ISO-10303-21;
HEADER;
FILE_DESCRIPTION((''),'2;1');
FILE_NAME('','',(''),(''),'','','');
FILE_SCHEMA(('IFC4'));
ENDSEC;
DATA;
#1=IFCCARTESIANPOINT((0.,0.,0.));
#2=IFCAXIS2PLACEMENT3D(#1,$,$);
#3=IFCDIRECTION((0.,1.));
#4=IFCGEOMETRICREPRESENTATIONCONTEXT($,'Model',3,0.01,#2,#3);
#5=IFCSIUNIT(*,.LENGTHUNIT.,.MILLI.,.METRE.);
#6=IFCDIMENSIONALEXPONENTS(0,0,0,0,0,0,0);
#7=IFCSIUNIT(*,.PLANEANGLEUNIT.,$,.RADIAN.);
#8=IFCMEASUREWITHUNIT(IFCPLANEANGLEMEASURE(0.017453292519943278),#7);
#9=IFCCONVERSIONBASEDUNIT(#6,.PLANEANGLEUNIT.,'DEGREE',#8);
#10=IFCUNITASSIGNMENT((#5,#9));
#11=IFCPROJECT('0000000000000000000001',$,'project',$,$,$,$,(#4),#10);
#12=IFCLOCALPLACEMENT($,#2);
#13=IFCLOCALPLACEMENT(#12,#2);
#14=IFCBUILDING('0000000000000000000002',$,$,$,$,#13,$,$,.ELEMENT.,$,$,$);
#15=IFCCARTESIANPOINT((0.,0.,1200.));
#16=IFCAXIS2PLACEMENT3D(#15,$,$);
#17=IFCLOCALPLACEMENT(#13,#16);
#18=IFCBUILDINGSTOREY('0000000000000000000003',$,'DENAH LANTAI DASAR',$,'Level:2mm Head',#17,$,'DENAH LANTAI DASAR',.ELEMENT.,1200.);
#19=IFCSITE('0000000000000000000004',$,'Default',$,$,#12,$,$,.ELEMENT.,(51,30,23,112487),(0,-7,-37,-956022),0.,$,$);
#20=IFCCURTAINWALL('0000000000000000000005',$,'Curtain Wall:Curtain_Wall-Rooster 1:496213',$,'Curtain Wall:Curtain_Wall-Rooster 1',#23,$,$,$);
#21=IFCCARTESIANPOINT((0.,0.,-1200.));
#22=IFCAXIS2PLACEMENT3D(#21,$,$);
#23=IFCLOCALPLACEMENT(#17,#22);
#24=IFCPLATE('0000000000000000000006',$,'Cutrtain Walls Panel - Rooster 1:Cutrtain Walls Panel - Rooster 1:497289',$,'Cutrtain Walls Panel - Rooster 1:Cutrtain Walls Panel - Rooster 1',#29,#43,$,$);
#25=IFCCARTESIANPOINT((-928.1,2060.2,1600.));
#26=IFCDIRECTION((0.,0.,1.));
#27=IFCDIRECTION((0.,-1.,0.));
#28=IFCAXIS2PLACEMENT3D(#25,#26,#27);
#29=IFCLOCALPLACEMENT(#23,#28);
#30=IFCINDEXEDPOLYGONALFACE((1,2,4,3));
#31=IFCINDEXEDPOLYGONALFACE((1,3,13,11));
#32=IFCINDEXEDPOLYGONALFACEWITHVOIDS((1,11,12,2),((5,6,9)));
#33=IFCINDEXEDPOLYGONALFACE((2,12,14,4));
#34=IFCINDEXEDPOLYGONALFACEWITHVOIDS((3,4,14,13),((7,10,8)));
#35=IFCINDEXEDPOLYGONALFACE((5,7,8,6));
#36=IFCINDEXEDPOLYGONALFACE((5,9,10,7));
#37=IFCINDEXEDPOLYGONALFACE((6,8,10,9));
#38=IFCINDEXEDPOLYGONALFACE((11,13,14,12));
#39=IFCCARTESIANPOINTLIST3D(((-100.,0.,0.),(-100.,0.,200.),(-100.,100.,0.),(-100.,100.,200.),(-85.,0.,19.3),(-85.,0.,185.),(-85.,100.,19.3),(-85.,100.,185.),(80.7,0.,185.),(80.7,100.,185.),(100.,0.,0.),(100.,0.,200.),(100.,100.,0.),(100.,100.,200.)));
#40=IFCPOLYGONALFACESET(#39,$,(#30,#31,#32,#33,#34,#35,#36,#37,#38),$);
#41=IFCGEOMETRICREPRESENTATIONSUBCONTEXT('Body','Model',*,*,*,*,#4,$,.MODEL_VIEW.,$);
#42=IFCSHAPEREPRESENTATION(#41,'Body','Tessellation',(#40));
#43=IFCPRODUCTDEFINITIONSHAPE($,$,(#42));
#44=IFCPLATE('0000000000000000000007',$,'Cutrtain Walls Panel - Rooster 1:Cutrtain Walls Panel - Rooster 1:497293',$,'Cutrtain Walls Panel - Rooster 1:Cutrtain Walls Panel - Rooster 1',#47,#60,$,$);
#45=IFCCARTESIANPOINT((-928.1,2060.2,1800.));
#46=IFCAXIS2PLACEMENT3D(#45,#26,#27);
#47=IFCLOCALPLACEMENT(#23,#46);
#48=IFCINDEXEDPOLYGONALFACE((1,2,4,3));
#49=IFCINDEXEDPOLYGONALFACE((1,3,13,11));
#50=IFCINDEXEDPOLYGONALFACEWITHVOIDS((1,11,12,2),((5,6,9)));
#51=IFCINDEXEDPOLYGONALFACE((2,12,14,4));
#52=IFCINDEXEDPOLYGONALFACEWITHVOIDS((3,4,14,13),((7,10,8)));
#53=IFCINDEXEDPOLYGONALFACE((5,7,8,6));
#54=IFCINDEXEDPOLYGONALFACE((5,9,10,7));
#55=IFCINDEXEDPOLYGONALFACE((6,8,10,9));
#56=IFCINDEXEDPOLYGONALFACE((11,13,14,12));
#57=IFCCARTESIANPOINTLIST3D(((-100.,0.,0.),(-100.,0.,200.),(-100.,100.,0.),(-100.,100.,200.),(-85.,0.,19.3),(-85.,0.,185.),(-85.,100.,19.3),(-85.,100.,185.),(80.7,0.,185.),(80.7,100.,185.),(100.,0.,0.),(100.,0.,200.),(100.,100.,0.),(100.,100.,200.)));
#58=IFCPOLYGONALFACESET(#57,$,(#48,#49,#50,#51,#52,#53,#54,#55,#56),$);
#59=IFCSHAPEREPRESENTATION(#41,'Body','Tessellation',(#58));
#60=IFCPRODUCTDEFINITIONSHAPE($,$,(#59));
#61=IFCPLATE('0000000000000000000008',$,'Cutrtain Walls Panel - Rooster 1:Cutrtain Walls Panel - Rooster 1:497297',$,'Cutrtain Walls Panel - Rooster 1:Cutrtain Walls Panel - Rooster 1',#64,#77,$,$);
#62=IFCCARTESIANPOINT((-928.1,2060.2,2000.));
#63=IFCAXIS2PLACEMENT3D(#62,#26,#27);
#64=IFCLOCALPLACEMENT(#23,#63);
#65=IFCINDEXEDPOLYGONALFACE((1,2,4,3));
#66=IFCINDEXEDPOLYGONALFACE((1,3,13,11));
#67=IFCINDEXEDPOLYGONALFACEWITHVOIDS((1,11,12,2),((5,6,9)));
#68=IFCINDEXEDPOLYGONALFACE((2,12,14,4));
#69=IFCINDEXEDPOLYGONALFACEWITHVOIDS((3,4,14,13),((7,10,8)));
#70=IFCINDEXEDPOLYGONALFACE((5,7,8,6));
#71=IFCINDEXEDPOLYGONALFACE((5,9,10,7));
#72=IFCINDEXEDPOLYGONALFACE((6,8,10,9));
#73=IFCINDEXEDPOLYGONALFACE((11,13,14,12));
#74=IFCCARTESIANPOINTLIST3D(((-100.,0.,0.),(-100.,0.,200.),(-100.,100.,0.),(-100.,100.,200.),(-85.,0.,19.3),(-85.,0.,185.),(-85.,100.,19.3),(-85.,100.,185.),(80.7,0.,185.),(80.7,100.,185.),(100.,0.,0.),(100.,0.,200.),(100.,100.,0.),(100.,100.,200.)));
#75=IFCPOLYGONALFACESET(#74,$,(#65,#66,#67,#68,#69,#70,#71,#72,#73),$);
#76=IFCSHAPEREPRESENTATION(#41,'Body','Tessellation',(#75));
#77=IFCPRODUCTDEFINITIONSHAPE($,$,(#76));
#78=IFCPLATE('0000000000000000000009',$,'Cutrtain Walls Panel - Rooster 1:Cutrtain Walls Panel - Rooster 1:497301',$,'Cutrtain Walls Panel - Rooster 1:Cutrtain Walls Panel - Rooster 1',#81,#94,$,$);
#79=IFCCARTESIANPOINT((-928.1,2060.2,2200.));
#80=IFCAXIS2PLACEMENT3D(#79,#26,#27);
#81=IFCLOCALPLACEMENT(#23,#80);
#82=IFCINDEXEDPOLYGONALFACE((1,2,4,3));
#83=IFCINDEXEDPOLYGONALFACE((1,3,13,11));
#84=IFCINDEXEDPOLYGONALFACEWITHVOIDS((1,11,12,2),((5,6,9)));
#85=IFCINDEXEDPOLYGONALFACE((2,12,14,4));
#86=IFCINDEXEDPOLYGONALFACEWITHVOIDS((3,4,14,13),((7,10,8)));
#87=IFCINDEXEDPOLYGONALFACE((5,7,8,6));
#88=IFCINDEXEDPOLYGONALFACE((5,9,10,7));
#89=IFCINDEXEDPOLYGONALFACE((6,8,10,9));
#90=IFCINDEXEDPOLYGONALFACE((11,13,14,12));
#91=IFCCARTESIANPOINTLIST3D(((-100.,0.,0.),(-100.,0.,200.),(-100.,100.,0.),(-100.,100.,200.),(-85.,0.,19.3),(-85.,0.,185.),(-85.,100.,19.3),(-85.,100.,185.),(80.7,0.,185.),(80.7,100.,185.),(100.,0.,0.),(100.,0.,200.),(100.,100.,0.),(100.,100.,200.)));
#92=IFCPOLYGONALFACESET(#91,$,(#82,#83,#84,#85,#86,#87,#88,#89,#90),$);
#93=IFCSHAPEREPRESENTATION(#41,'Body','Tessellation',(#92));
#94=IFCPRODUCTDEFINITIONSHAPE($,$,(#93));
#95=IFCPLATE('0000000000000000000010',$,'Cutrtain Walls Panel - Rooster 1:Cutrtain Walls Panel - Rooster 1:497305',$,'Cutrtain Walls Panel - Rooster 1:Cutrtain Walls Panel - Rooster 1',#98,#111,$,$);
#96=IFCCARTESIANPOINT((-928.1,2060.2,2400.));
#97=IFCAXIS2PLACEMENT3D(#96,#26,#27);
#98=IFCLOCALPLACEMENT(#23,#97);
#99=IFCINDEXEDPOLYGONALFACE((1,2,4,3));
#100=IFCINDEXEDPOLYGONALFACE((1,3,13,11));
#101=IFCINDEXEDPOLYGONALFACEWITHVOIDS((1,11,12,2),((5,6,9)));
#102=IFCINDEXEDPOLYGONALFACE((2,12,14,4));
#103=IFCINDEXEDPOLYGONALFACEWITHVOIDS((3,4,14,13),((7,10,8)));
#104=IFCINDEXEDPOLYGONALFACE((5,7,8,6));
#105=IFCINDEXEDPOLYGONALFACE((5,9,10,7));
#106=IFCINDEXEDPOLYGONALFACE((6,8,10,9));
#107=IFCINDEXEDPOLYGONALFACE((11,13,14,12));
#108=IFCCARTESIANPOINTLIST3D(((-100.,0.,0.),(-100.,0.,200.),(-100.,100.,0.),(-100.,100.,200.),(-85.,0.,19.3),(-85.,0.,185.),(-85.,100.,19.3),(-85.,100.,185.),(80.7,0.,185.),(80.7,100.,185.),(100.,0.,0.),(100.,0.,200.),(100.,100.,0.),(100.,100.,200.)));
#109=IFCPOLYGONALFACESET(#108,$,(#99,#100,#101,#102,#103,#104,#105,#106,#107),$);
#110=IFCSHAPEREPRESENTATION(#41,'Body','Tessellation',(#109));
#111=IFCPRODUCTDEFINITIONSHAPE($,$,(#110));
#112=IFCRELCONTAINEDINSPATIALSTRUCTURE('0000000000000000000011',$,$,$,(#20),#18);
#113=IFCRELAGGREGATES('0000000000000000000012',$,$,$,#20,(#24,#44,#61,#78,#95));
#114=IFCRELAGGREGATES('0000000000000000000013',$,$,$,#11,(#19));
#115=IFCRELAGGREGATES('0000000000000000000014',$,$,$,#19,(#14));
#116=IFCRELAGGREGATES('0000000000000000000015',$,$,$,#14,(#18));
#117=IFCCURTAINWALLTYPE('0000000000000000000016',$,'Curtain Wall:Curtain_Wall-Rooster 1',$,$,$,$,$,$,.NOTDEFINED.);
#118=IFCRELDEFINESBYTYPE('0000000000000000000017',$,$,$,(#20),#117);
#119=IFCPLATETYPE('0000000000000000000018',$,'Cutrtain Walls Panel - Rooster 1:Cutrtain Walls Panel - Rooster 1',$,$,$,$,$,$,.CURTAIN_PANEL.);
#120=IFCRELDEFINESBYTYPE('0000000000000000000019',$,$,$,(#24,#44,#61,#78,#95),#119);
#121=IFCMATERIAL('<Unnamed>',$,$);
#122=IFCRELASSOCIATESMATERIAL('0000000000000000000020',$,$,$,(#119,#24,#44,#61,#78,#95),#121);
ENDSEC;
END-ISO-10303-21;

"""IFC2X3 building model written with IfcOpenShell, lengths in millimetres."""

from ifc_helpers import new_model, entity, si_unit, converted_unit, direction, frame, origin, place, context, subcontext, project, spatial, polyline, outline, extrude, source, transform, mapped, material, type_object, type_shapes, element, aggregate, save


model = new_model("IFC2X3")

# Units and contexts
model_context = context("Model", 3, precision=0.01, world=origin(), true_north=direction((0.0, 1.0)))
body_context = subcontext(model_context, "Body", "Model", "MODEL_VIEW")
ifc_project = project(units=[si_unit("LENGTHUNIT", "METRE", prefix="MILLI"), converted_unit("PLANEANGLEUNIT", "DEGREE", entity("IfcPlaneAngleMeasure", 0.017453292519943278), si_unit("PLANEANGLEUNIT", "RADIAN"), dimensions=[0, 0, 0, 0, 0, 0, 0])], contexts=[model_context])

# Site, building, storey
site_placement = place(None, origin())
site = spatial("IfcSite", under=ifc_project, at=site_placement, Name="Default", CompositionType="ELEMENT", RefLatitude=(51, 30, 23, 112487), RefLongitude=(0, -7, -37, -956022), RefElevation=0.0)
building_placement = place(site_placement, origin())
building = spatial("IfcBuilding", under=site, at=building_placement, CompositionType="ELEMENT")
storey_placement = place(building_placement, frame((0.0, 0.0, 1200.0)))
storey = spatial("IfcBuildingStorey", under=building, at=storey_placement, Name="DENAH LANTAI DASAR", ObjectType="Level:2mm Head", LongName="DENAH LANTAI DASAR", CompositionType="ELEMENT", Elevation=1200.0)

# Curtain wall, plates
curtain_wall_type = type_object("IfcCurtainWallType", Name="Curtain Wall:Curtain_Wall-Rooster 1", PredefinedType="NOTDEFINED")
ifc_material_1 = material(Name="<Unnamed>")
plate_type_1 = type_object("IfcPlateType", Name="Cutrtain Walls Panel - Rooster 1:Cutrtain Walls Panel - Rooster 1", PredefinedType="CURTAIN_PANEL", material=ifc_material_1)
shared_shape_1 = source(origin(), body_context, "Body", "SweptSolid", [
    extrude(outline(polyline([(-100.0, -100.0), (100.0, -100.0), (100.0, 100.0), (-100.0, 100.0), (-100.0, -100.0)]), holes=[polyline([(80.7, 85.0), (-85.0, -80.7), (-85.0, 85.0), (80.7, 85.0)])]), frame((0.0, 0.0, 100.0), z_axis=(0.0, 1.0, 0.0), x_axis=(0.0, 0.0, -1.0)), (0.0, 0.0, 1.0), 100.0),
])
type_shapes(plate_type_1, [shared_shape_1])
curtain_wall_1_placement = place(storey_placement, frame((0.0, 0.0, -1200.0)))
curtain_wall_1 = element("IfcCurtainWall", 1, at=curtain_wall_1_placement, inside=storey, type_object=curtain_wall_type, Name="Curtain Wall:Curtain_Wall-Rooster 1:496213", ObjectType="Curtain Wall:Curtain_Wall-Rooster 1")
plate_1_placement = place(curtain_wall_1_placement, frame((-928.1, 2060.2, 1600.0), z_axis=(0.0, 0.0, 1.0), x_axis=(0.0, -1.0, 0.0)))
plate_1 = element("IfcPlate", 2, at=plate_1_placement, type_object=plate_type_1, material=ifc_material_1, Name="Cutrtain Walls Panel - Rooster 1:Cutrtain Walls Panel - Rooster 1:497289", ObjectType="Cutrtain Walls Panel - Rooster 1:Cutrtain Walls Panel - Rooster 1", context=body_context, shape_type="MappedRepresentation", body=[
    mapped(shared_shape_1, transform((0.0, 0.0, 0.0), scale=1.0)),
])
plate_2_placement = place(curtain_wall_1_placement, frame((-928.1, 2060.2, 1800.0), z_axis=(0.0, 0.0, 1.0), x_axis=(0.0, -1.0, 0.0)))
plate_2 = element("IfcPlate", 3, at=plate_2_placement, type_object=plate_type_1, material=ifc_material_1, Name="Cutrtain Walls Panel - Rooster 1:Cutrtain Walls Panel - Rooster 1:497293", ObjectType="Cutrtain Walls Panel - Rooster 1:Cutrtain Walls Panel - Rooster 1", context=body_context, shape_type="MappedRepresentation", body=[
    mapped(shared_shape_1, transform((0.0, 0.0, 0.0), scale=1.0)),
])
plate_3_placement = place(curtain_wall_1_placement, frame((-928.1, 2060.2, 2000.0), z_axis=(0.0, 0.0, 1.0), x_axis=(0.0, -1.0, 0.0)))
plate_3 = element("IfcPlate", 4, at=plate_3_placement, type_object=plate_type_1, material=ifc_material_1, Name="Cutrtain Walls Panel - Rooster 1:Cutrtain Walls Panel - Rooster 1:497297", ObjectType="Cutrtain Walls Panel - Rooster 1:Cutrtain Walls Panel - Rooster 1", context=body_context, shape_type="MappedRepresentation", body=[
    mapped(shared_shape_1, transform((0.0, 0.0, 0.0), scale=1.0)),
])
plate_4_placement = place(curtain_wall_1_placement, frame((-928.1, 2060.2, 2200.0), z_axis=(0.0, 0.0, 1.0), x_axis=(0.0, -1.0, 0.0)))
plate_4 = element("IfcPlate", 5, at=plate_4_placement, type_object=plate_type_1, material=ifc_material_1, Name="Cutrtain Walls Panel - Rooster 1:Cutrtain Walls Panel - Rooster 1:497301", ObjectType="Cutrtain Walls Panel - Rooster 1:Cutrtain Walls Panel - Rooster 1", context=body_context, shape_type="MappedRepresentation", body=[
    mapped(shared_shape_1, transform((0.0, 0.0, 0.0), scale=1.0)),
])
plate_5_placement = place(curtain_wall_1_placement, frame((-928.1, 2060.2, 2400.0), z_axis=(0.0, 0.0, 1.0), x_axis=(0.0, -1.0, 0.0)))
plate_5 = element("IfcPlate", 6, at=plate_5_placement, type_object=plate_type_1, material=ifc_material_1, Name="Cutrtain Walls Panel - Rooster 1:Cutrtain Walls Panel - Rooster 1:497305", ObjectType="Cutrtain Walls Panel - Rooster 1:Cutrtain Walls Panel - Rooster 1", context=body_context, shape_type="MappedRepresentation", body=[
    mapped(shared_shape_1, transform((0.0, 0.0, 0.0), scale=1.0)),
])
aggregate(curtain_wall_1, [plate_1, plate_2, plate_3, plate_4, plate_5])

save(model, "model.ifc")
